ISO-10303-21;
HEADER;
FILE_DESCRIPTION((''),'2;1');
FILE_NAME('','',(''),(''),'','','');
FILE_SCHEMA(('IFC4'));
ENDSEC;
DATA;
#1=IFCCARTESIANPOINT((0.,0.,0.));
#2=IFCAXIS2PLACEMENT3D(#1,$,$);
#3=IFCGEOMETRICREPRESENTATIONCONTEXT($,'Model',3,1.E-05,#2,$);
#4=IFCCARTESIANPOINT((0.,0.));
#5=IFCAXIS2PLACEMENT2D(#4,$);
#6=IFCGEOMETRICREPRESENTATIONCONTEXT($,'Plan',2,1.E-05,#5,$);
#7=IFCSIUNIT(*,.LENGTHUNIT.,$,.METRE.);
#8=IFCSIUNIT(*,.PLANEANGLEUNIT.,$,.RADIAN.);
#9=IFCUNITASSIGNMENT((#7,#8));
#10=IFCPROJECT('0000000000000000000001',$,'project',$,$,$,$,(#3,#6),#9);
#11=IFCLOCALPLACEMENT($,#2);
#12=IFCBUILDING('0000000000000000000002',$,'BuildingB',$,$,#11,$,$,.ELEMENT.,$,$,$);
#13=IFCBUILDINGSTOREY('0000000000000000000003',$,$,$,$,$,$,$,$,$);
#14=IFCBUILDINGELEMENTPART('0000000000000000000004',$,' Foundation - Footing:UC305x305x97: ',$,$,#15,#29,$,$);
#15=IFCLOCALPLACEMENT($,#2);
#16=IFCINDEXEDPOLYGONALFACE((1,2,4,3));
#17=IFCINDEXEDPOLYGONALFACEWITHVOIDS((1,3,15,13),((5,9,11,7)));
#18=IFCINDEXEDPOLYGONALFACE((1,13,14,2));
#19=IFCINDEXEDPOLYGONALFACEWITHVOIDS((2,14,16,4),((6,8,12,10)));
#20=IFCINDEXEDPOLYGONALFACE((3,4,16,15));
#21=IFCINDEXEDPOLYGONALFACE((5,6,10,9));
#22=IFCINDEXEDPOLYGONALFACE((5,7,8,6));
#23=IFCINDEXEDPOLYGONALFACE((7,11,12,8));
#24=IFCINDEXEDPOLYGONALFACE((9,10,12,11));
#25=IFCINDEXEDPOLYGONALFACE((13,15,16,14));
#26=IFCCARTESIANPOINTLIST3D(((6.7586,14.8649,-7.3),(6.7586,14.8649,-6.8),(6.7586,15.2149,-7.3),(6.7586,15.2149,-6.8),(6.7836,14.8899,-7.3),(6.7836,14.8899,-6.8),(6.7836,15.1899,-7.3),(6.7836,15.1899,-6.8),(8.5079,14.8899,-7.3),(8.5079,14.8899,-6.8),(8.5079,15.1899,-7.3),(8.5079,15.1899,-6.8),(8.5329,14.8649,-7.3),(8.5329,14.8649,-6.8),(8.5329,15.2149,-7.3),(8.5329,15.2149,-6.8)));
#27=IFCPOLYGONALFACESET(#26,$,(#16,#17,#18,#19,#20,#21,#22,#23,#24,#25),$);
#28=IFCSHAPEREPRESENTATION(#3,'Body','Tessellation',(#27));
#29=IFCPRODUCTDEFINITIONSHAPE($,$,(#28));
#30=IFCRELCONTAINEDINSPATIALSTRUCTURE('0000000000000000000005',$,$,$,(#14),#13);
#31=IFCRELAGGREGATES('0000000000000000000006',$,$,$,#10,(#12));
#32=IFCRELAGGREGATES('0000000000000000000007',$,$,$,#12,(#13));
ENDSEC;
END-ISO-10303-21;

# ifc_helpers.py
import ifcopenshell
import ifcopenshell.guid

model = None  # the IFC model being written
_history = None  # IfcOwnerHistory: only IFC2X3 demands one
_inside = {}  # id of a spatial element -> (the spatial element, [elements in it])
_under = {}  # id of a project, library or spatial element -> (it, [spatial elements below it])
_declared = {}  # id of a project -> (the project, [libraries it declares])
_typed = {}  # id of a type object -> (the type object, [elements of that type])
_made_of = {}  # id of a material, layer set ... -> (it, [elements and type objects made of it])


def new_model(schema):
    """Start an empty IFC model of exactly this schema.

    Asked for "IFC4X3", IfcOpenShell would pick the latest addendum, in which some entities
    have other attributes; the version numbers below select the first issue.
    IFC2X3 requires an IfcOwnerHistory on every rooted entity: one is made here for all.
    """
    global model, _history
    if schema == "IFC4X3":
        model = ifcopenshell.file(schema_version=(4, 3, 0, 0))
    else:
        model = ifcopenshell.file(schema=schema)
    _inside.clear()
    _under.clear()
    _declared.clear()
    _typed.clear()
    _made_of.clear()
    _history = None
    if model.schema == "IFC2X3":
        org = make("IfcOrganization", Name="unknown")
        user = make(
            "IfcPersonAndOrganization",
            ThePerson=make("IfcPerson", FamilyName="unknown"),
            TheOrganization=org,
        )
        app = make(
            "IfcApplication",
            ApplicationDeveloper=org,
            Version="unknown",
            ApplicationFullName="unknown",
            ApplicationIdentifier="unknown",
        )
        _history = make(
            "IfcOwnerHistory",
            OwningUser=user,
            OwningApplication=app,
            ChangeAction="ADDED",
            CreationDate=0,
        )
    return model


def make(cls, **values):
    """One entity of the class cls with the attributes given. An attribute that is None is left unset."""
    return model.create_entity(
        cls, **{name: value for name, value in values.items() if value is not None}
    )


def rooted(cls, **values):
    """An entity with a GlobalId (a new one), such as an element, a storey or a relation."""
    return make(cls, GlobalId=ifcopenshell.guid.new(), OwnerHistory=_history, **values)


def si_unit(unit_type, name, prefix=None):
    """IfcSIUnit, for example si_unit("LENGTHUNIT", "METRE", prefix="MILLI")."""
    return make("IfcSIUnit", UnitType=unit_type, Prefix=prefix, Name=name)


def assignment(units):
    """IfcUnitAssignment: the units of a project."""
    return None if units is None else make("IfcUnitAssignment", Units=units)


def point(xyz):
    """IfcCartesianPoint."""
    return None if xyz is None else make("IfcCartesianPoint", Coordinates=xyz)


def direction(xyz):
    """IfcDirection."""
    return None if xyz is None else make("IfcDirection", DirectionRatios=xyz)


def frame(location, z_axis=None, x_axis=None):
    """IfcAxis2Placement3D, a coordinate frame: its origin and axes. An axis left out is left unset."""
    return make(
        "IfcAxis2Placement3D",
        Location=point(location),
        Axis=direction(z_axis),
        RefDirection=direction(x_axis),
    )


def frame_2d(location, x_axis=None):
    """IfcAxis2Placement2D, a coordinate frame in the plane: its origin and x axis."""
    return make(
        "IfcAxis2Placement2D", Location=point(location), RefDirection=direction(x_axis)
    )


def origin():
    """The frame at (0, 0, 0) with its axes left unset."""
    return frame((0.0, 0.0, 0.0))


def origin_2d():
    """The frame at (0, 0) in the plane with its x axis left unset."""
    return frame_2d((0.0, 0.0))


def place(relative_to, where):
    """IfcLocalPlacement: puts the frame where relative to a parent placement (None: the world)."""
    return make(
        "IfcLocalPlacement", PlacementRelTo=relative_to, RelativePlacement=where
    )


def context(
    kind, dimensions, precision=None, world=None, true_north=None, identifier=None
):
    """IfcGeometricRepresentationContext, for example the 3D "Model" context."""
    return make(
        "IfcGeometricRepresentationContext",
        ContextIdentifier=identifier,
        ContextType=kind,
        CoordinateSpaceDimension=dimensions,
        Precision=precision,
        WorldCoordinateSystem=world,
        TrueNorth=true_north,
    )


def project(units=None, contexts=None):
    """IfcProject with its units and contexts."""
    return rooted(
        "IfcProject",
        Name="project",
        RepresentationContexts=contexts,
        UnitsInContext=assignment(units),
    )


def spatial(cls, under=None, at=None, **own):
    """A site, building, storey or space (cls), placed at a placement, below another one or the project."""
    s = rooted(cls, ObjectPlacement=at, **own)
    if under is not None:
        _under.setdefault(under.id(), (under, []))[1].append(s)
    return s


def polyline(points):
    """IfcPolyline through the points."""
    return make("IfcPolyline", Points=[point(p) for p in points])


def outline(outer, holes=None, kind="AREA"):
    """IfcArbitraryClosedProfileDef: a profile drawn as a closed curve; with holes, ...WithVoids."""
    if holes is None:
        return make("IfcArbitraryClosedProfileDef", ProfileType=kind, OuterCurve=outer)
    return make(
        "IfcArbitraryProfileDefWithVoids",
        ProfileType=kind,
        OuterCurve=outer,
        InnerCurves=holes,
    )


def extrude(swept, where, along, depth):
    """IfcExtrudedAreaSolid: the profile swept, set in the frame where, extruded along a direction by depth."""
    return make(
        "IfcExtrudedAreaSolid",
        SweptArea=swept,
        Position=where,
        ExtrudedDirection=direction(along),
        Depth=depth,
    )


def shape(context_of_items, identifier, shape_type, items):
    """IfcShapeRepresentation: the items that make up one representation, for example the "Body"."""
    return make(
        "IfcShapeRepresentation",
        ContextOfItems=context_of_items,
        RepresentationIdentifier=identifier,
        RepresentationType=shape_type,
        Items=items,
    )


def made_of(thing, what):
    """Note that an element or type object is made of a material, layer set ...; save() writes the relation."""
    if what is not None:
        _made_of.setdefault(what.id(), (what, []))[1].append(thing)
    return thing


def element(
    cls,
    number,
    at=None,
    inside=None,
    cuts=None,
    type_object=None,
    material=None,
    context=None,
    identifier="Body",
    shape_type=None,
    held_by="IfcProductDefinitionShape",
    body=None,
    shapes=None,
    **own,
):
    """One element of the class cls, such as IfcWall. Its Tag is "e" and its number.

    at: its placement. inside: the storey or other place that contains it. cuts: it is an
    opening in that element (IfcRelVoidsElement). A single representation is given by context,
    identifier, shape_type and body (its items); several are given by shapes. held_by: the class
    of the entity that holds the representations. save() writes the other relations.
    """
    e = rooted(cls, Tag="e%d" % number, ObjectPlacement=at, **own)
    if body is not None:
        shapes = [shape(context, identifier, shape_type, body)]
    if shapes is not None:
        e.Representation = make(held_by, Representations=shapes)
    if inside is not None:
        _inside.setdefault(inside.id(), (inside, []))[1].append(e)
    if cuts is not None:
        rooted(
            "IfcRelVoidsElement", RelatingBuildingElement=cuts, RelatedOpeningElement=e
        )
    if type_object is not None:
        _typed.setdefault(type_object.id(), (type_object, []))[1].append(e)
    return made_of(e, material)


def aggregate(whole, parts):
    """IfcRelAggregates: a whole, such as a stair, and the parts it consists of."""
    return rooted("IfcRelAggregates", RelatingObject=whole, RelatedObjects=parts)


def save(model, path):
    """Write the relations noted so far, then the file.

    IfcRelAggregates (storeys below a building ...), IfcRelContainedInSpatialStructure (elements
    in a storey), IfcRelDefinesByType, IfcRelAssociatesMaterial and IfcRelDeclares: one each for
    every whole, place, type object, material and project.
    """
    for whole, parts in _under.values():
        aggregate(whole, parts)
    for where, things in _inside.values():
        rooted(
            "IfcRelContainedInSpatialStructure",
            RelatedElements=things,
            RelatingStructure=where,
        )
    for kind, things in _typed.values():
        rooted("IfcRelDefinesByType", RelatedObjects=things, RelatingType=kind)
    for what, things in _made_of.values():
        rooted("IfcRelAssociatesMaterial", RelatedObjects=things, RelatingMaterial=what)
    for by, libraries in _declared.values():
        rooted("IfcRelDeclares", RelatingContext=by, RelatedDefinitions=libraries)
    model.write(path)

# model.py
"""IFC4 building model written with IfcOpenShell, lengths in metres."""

from ifc_helpers import new_model, si_unit, origin, origin_2d, place, context, project, spatial, polyline, outline, extrude, element, save


model = new_model("IFC4")

# Units and contexts
model_context = context("Model", 3, precision=1e-05, world=origin())
plan_context = context("Plan", 2, precision=1e-05, world=origin_2d())
ifc_project = project(units=[si_unit("LENGTHUNIT", "METRE"), si_unit("PLANEANGLEUNIT", "RADIAN")], contexts=[model_context, plan_context])

# Building, storey
building_placement = place(None, origin())
building = spatial("IfcBuilding", under=ifc_project, at=building_placement, Name="BuildingB", CompositionType="ELEMENT")
storey = spatial("IfcBuildingStorey", under=building)

# Building element part, opening
building_element_part_1 = element("IfcBuildingElementPart", 1, inside=storey, Name=" Foundation - Footing:UC305x305x97: ", context=model_context, shape_type="SweptSolid", body=[
    extrude(outline(polyline([(6.7586, 14.8649, -7.3), (6.7586, 15.2149, -7.3), (8.5329, 15.2149, -7.3), (8.5329, 14.8649, -7.3), (6.7586, 14.8649, -7.3)])), None, (0.0, 0.0, 1.0), 0.5),
])
element("IfcOpeningElement", 2, inside=storey, cuts=building_element_part_1, context=model_context, shape_type="SweptSolid", body=[
    extrude(outline(polyline([(6.7836, 14.8899, -7.3), (6.7836, 15.1899, -7.3), (8.5079, 15.1899, -7.3), (8.5079, 14.8899, -7.3), (6.7836, 14.8899, -7.3)])), None, (0.0, 0.0, 1.0), 0.5),
])

save(model, "model.ifc")
